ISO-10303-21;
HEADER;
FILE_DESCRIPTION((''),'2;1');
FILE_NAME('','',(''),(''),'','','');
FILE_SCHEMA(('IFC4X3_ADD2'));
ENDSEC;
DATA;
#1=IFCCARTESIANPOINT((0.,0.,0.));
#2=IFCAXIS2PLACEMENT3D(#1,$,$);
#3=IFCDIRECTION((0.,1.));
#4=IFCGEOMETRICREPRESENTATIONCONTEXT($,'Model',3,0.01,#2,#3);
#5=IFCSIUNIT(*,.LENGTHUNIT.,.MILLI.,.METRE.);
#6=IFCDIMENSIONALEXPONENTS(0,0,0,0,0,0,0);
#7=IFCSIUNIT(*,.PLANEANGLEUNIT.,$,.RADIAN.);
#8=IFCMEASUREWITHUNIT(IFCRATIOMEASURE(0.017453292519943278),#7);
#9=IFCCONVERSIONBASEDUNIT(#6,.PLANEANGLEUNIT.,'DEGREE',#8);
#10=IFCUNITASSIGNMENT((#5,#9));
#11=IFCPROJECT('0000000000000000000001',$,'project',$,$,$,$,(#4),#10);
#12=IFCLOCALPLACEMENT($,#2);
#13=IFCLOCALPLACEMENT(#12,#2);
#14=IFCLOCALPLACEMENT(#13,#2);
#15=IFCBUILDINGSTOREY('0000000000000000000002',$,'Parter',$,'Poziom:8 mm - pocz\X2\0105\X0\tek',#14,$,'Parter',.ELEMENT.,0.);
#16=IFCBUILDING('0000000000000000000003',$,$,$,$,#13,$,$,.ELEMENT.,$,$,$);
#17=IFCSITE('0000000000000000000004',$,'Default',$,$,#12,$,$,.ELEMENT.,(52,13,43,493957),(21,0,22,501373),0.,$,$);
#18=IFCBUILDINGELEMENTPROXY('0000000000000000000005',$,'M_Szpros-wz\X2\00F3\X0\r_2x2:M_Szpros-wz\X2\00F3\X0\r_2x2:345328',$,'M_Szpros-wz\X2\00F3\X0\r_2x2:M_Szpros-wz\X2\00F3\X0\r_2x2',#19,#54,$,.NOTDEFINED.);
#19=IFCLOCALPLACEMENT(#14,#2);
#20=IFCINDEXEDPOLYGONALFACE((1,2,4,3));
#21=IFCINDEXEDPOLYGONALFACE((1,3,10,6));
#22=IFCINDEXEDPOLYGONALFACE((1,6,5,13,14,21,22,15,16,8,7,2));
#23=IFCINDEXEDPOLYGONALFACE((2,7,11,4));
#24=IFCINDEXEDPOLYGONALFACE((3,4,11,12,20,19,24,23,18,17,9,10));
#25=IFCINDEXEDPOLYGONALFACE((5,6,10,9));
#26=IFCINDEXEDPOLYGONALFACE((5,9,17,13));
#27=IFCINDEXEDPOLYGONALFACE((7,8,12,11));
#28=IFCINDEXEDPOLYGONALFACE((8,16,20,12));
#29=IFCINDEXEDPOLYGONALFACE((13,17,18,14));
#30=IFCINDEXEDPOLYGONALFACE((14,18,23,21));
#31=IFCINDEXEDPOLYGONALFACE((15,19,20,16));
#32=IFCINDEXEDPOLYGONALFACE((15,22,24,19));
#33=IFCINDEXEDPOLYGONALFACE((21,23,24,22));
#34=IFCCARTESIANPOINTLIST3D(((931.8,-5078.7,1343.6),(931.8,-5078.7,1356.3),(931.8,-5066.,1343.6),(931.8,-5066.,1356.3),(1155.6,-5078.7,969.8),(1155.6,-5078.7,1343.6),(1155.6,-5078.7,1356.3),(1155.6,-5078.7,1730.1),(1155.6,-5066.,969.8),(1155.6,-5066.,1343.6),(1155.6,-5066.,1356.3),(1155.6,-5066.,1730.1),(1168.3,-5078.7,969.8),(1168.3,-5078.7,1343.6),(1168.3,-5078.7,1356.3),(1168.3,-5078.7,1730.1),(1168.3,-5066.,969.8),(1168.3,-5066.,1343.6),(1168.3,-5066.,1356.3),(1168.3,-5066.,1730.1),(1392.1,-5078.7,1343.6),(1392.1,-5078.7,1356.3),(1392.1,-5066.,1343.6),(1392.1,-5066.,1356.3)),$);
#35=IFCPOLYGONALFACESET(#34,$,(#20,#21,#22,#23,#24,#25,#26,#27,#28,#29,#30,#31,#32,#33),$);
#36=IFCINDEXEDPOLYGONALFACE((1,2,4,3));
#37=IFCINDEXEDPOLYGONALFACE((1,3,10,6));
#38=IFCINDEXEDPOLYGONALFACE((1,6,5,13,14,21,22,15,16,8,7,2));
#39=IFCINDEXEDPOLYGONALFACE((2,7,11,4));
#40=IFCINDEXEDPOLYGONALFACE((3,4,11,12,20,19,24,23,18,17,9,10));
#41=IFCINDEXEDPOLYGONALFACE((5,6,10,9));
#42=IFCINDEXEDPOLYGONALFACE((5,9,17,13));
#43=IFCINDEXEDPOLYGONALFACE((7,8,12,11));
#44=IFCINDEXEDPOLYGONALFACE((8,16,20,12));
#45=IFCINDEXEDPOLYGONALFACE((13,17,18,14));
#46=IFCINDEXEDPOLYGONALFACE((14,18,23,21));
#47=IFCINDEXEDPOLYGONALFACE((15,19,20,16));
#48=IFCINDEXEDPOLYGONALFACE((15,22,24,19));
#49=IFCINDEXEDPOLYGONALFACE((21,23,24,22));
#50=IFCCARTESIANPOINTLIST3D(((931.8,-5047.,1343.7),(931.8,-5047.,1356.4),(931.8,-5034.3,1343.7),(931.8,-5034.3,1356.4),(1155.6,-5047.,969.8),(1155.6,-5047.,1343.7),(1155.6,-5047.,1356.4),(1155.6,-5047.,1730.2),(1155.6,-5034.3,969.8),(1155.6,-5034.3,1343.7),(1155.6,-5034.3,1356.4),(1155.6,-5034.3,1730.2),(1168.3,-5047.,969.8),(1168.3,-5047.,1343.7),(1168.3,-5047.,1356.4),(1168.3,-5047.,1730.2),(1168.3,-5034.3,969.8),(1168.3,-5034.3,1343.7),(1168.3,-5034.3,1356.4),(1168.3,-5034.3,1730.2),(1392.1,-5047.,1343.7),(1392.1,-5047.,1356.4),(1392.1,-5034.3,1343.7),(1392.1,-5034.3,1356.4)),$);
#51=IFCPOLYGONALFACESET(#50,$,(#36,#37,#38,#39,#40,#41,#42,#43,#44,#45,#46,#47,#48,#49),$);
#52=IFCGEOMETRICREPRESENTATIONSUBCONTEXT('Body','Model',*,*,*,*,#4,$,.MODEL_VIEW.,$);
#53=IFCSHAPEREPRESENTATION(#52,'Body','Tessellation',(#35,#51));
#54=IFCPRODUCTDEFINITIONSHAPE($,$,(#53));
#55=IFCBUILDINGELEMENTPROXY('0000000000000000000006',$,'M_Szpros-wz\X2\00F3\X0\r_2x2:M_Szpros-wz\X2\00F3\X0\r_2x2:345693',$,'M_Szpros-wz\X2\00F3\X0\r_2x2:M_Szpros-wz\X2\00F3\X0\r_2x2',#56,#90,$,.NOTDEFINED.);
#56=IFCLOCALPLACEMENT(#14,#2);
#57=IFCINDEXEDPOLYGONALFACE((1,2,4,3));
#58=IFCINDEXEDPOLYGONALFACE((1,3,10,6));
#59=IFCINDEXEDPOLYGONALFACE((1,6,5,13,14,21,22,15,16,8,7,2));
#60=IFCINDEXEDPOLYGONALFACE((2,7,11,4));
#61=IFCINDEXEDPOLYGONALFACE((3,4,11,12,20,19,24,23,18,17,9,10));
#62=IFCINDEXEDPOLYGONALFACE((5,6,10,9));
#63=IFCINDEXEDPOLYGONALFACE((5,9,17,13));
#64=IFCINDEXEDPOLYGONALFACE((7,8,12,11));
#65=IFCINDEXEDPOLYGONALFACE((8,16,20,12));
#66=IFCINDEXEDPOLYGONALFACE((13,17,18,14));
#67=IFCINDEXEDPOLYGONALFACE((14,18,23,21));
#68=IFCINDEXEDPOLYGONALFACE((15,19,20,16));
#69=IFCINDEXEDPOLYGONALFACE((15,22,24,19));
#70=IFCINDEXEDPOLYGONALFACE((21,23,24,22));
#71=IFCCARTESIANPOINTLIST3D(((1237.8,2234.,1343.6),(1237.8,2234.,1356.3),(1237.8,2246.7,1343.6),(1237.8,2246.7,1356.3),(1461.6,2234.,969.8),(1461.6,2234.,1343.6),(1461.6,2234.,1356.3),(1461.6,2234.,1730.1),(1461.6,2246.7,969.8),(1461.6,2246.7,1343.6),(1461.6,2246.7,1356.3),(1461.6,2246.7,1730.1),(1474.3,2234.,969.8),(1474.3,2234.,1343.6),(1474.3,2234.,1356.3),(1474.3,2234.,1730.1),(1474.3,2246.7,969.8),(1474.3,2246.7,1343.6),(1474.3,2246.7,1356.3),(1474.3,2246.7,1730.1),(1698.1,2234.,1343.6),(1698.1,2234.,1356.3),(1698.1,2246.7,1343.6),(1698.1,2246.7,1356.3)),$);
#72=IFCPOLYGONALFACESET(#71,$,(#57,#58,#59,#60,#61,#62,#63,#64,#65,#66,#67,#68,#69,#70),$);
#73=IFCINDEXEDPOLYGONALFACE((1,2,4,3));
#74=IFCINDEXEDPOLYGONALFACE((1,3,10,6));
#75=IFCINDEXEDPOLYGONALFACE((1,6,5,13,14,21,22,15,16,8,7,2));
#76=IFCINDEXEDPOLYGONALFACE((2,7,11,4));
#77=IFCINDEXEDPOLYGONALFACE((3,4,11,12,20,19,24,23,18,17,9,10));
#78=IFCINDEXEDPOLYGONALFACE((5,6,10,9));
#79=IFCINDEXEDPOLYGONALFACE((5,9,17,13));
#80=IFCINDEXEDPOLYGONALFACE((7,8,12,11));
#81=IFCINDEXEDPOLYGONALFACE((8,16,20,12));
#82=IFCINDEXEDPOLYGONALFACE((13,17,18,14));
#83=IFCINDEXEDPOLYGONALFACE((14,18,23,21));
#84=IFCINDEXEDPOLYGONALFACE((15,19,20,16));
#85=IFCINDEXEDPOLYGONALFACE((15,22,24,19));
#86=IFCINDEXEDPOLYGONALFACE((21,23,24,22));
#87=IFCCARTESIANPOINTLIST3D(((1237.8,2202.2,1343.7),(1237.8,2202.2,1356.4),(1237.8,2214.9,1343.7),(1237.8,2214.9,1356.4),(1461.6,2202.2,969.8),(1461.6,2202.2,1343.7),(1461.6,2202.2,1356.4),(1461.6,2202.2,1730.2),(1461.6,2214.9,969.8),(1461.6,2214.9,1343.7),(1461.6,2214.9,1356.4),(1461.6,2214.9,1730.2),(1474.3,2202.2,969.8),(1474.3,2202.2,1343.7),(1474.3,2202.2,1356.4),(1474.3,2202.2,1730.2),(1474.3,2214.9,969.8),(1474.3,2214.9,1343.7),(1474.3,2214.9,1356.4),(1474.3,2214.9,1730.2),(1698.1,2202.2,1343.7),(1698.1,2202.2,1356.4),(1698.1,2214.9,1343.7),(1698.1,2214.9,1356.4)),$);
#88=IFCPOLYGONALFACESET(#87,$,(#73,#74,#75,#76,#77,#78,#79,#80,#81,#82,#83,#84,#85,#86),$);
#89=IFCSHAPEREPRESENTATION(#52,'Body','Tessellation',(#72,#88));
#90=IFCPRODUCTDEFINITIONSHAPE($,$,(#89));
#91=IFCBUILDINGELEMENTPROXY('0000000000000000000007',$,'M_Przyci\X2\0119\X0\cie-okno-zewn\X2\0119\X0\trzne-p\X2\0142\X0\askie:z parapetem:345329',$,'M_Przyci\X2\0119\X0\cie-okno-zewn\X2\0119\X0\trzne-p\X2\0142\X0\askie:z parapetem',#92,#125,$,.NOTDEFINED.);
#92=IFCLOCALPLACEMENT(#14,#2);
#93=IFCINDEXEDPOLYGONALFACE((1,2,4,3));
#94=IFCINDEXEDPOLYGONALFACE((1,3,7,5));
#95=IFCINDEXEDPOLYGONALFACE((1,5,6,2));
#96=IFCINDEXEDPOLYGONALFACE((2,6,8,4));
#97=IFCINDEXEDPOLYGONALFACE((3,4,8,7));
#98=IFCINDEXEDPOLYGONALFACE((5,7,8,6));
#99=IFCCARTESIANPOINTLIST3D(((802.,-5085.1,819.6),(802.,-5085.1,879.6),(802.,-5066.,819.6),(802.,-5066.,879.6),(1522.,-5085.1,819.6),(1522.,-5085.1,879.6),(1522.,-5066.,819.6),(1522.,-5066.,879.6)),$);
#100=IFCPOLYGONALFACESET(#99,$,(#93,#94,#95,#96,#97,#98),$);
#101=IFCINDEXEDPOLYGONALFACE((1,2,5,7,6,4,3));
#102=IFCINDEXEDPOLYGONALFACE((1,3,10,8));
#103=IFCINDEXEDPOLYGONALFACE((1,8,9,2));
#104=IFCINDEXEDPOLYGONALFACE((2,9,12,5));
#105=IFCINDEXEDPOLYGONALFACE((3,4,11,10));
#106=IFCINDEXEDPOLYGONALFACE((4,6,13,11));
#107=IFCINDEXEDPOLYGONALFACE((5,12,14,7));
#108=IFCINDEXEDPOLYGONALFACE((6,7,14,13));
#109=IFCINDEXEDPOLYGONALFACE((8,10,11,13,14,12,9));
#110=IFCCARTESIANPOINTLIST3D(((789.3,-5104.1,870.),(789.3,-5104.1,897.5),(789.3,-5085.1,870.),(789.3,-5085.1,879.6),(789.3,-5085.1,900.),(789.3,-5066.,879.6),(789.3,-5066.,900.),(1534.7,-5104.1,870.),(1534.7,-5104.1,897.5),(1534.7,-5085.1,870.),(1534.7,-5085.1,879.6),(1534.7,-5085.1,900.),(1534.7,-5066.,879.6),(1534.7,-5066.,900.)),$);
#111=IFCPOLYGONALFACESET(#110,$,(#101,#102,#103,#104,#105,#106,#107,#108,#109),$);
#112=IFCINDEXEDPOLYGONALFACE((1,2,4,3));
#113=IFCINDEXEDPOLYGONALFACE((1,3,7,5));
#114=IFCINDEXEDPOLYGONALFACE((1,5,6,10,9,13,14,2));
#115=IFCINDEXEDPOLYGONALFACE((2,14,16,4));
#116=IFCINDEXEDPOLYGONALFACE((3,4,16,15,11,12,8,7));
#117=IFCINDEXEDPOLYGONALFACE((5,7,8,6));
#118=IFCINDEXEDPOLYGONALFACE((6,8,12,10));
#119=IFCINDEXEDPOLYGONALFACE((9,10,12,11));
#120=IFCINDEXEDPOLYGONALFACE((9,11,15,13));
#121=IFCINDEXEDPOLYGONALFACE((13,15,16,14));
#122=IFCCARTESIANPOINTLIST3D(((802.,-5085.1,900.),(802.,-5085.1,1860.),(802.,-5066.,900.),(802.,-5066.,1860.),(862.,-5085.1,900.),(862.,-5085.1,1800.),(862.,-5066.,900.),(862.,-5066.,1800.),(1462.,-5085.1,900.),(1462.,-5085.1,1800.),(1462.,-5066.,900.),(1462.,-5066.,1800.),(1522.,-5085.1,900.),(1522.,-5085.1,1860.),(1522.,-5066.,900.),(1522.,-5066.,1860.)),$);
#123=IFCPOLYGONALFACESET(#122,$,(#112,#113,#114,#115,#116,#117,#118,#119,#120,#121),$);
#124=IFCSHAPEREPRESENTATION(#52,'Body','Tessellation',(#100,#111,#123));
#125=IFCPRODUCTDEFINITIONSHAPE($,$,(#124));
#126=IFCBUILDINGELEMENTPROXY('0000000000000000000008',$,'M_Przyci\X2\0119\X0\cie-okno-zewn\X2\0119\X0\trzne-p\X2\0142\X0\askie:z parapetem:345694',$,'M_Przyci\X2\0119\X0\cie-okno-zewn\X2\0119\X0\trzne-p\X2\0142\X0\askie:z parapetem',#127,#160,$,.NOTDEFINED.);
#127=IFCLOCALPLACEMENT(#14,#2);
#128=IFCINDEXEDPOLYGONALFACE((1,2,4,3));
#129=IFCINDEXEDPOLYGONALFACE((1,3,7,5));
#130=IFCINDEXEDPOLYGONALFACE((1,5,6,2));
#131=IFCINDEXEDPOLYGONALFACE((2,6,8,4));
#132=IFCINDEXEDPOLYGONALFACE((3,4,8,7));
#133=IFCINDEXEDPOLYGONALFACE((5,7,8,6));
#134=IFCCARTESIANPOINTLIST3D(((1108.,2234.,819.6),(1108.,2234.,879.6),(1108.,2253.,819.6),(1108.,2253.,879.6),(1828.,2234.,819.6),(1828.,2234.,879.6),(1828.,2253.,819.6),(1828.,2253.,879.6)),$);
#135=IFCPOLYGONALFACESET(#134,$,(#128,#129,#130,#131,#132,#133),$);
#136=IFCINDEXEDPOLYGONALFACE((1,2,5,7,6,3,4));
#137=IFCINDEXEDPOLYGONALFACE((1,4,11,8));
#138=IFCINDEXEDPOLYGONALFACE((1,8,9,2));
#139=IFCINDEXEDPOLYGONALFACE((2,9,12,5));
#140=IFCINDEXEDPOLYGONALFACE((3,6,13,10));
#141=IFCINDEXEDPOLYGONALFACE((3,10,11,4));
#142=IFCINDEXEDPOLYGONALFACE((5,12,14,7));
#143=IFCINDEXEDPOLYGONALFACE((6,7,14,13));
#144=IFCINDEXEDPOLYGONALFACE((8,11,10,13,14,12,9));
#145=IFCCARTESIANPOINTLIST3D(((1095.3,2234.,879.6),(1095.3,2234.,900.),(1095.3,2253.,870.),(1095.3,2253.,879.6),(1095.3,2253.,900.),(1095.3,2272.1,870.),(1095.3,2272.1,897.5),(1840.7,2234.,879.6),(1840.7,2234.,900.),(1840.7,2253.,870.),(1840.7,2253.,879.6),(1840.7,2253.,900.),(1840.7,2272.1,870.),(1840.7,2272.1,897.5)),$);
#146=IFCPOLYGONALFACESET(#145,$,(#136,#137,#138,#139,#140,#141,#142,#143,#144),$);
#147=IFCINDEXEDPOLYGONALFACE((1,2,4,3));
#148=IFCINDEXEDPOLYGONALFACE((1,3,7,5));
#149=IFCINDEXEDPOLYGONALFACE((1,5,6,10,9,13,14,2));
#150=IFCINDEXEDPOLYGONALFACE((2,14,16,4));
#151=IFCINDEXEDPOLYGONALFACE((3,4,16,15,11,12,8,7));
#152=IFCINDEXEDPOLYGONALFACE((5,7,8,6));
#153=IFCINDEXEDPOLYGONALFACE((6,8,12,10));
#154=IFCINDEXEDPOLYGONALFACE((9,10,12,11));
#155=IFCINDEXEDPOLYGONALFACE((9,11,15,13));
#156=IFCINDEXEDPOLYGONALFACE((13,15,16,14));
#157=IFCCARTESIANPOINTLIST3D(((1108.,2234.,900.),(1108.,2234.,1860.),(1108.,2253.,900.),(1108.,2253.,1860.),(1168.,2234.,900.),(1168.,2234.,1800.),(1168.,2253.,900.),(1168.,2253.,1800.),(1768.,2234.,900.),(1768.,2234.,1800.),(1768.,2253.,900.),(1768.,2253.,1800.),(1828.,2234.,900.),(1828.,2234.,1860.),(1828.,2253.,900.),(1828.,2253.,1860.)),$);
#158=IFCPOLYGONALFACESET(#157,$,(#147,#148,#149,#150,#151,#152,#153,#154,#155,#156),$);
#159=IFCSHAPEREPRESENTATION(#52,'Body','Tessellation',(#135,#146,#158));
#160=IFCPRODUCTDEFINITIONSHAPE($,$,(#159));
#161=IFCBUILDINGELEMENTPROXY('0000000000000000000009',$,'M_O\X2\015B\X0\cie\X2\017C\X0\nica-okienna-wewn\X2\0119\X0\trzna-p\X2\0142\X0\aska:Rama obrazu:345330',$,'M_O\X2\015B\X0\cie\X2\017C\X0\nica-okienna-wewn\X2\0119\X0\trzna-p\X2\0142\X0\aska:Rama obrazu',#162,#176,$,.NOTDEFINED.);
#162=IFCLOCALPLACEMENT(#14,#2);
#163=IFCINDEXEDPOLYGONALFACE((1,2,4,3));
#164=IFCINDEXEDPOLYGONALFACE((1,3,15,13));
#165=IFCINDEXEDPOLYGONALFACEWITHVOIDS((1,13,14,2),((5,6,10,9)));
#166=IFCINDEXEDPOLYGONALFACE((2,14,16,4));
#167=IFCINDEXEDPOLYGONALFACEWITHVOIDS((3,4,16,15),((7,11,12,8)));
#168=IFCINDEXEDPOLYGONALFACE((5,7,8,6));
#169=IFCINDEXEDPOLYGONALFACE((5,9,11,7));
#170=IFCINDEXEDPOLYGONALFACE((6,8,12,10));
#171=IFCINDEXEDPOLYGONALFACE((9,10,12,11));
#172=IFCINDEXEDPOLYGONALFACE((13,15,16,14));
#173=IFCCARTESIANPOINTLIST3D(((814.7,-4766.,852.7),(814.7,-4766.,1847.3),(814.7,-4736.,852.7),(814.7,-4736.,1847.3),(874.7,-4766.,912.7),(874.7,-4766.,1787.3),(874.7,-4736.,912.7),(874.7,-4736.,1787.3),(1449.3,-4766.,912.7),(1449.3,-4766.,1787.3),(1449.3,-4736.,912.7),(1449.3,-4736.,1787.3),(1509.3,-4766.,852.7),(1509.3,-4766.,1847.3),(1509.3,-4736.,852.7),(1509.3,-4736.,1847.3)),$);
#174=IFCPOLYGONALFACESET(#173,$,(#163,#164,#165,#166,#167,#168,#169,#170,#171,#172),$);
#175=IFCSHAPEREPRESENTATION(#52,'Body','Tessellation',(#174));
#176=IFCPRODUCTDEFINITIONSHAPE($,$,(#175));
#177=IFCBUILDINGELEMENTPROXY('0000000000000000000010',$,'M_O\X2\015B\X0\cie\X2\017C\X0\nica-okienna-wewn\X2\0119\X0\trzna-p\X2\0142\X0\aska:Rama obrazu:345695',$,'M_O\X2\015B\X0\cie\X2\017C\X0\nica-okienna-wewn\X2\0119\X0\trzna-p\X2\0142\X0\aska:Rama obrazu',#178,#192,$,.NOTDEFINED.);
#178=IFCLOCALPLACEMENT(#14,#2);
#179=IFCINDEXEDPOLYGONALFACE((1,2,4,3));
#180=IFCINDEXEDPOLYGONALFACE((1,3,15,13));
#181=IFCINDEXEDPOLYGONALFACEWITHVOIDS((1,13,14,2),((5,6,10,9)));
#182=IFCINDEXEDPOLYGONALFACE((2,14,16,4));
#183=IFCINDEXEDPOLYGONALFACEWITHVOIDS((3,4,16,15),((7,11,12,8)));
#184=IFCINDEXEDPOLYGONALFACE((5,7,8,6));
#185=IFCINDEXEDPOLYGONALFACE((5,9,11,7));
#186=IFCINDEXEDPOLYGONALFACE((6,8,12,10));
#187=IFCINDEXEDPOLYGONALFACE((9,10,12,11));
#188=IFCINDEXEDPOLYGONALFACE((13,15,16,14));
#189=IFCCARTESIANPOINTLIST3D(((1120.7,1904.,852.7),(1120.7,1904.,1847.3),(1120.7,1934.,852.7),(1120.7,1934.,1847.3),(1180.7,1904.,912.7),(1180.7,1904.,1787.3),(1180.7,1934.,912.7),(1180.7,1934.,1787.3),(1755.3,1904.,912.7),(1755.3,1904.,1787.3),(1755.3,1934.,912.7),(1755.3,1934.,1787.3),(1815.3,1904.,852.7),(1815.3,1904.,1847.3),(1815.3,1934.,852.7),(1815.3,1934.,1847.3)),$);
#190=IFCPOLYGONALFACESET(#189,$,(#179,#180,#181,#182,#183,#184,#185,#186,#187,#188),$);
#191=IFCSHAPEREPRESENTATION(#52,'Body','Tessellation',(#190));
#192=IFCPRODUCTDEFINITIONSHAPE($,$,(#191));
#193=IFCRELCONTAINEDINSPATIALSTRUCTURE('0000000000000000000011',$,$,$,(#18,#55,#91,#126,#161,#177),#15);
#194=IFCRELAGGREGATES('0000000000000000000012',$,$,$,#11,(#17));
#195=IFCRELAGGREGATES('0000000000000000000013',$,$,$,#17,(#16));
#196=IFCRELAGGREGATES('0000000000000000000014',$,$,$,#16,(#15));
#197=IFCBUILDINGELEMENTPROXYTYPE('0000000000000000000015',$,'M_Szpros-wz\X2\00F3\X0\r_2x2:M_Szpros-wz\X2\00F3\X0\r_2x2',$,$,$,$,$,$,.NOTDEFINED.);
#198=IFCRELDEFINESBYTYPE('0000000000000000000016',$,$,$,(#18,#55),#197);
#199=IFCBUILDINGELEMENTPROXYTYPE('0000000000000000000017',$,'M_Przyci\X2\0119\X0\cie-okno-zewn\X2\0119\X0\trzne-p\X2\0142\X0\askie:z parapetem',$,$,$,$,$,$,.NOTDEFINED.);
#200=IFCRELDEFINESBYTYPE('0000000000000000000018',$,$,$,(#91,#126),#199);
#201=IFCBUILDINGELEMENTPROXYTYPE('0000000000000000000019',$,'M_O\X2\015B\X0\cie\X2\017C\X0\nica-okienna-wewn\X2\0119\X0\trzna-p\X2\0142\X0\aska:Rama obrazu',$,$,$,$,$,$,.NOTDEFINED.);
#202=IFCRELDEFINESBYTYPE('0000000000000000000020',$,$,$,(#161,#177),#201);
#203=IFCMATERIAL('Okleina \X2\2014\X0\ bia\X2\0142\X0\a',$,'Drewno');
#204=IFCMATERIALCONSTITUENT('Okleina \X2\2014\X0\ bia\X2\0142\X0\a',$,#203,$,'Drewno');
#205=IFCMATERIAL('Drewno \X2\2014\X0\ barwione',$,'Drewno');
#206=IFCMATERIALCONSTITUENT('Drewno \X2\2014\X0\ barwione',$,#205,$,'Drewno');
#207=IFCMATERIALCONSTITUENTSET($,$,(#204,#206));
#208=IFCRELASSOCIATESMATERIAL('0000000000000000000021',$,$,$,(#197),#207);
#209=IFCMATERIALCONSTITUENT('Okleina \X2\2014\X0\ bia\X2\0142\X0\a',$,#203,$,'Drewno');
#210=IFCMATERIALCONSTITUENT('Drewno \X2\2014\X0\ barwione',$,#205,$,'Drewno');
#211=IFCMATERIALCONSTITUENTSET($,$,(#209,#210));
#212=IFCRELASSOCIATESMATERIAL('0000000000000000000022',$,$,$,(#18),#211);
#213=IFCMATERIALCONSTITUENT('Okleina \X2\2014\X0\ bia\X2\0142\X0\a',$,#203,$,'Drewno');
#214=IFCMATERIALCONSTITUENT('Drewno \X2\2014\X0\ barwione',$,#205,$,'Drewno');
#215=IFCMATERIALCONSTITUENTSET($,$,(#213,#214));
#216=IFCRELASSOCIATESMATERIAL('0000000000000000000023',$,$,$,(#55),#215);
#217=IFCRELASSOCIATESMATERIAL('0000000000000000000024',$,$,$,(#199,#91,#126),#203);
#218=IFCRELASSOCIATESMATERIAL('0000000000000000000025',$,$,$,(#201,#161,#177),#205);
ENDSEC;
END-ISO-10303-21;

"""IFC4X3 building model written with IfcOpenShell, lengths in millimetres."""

from ifc_helpers import new_model, entity, si_unit, converted_unit, direction, frame, frame_2d, origin, place, context, subcontext, project, spatial, polyline, rectangle, outline, extrude, source, transform, mapped, material, constituent, constituent_set, type_object, type_shapes, element, save


model = new_model("IFC4X3")

# Units and contexts
model_context = context("Model", 3, precision=0.01, world=origin(), true_north=direction((0.0, 1.0)))
body_context = subcontext(model_context, "Body", "Model", "MODEL_VIEW")
ifc_project = project(units=[si_unit("LENGTHUNIT", "METRE", prefix="MILLI"), converted_unit("PLANEANGLEUNIT", "DEGREE", entity("IfcRatioMeasure", 0.017453292519943278), si_unit("PLANEANGLEUNIT", "RADIAN"), dimensions=[0, 0, 0, 0, 0, 0, 0])], contexts=[model_context])

# Site, building, storey
site_placement = place(None, origin())
site = spatial("IfcSite", under=ifc_project, at=site_placement, Name="Default", CompositionType="ELEMENT", RefLatitude=(52, 13, 43, 493957), RefLongitude=(21, 0, 22, 501373), RefElevation=0.0)
building_placement = place(site_placement, origin())
building = spatial("IfcBuilding", under=site, at=building_placement, CompositionType="ELEMENT")
storey_placement = place(building_placement, origin())
storey = spatial("IfcBuildingStorey", under=building, at=storey_placement, Name="Parter", ObjectType="Poziom:8 mm - początek", LongName="Parter", CompositionType="ELEMENT", Elevation=0.0)

# Building element proxies
ifc_material_1 = material(Name="Okleina — biała", Category="Drewno")
ifc_constituent_1 = constituent(ifc_material_1, Name="Okleina — biała", Category="Drewno")
ifc_material_2 = material(Name="Drewno — barwione", Category="Drewno")
ifc_constituent_2 = constituent(ifc_material_2, Name="Drewno — barwione", Category="Drewno")
ifc_constituent_set_1 = constituent_set(constituents=[ifc_constituent_1, ifc_constituent_2])
ifc_constituent_3 = constituent(ifc_material_1, Name="Okleina — biała", Category="Drewno")
ifc_constituent_4 = constituent(ifc_material_2, Name="Drewno — barwione", Category="Drewno")
ifc_constituent_set_2 = constituent_set(constituents=[ifc_constituent_3, ifc_constituent_4])
building_element_proxy_type_1 = type_object("IfcBuildingElementProxyType", Name="M_Szpros-wzór_2x2:M_Szpros-wzór_2x2", PredefinedType="NOTDEFINED", material=ifc_constituent_set_2)
shared_shape_1 = source(origin(), body_context, "Body", "SweptSolid", [
    extrude(outline(polyline([(6.4, -6.4), (380.1, -6.4), (380.1, 6.3), (6.4, 6.3), (6.4, 230.2), (-6.3, 230.2), (-6.3, 6.3), (-380.2, 6.3), (-380.2, -6.4), (-6.3, -6.4), (-6.3, -230.1), (6.4, -230.1), (6.4, -6.4)])), frame((0.0, 9.5, 380.1), z_axis=(0.0, 1.0, 0.0), x_axis=(0.0, 0.0, 1.0)), (0.0, 0.0, 1.0), 12.7),
    extrude(outline(polyline([(6.4, -6.4), (380.2, -6.4), (380.2, 6.3), (6.4, 6.3), (6.4, 230.2), (-6.3, 230.2), (-6.3, 6.3), (-380.2, 6.3), (-380.2, -6.4), (-6.3, -6.4), (-6.3, -230.1), (6.4, -230.1), (6.4, -6.4)])), frame((0.0, -22.2, 380.2), z_axis=(0.0, 1.0, 0.0), x_axis=(0.0, 0.0, 1.0)), (0.0, 0.0, 1.0), 12.7),
])
type_shapes(building_element_proxy_type_1, [shared_shape_1])
proxy_1_placement = place(storey_placement, frame((1162.0, -5056.5, 969.8), z_axis=(0.0, 0.0, 1.0), x_axis=(-1.0, 0.0, 0.0)))
element("IfcBuildingElementProxy", 1, at=proxy_1_placement, inside=storey, type_object=building_element_proxy_type_1, material=ifc_constituent_set_1, Name="M_Szpros-wzór_2x2:M_Szpros-wzór_2x2:345328", ObjectType="M_Szpros-wzór_2x2:M_Szpros-wzór_2x2", PredefinedType="NOTDEFINED", context=body_context, shape_type="MappedRepresentation", body=[
    mapped(shared_shape_1, transform((0.0, 0.0, 0.0), scale=1.0)),
])
ifc_constituent_5 = constituent(ifc_material_1, Name="Okleina — biała", Category="Drewno")
ifc_constituent_6 = constituent(ifc_material_2, Name="Drewno — barwione", Category="Drewno")
ifc_constituent_set_3 = constituent_set(constituents=[ifc_constituent_5, ifc_constituent_6])
proxy_2_placement = place(storey_placement, frame((1468.0, 2224.5, 969.8)))
element("IfcBuildingElementProxy", 2, at=proxy_2_placement, inside=storey, type_object=building_element_proxy_type_1, material=ifc_constituent_set_3, Name="M_Szpros-wzór_2x2:M_Szpros-wzór_2x2:345693", ObjectType="M_Szpros-wzór_2x2:M_Szpros-wzór_2x2", PredefinedType="NOTDEFINED", context=body_context, shape_type="MappedRepresentation", body=[
    mapped(shared_shape_1, transform((0.0, 0.0, 0.0), scale=1.0)),
])
building_element_proxy_type_2 = type_object("IfcBuildingElementProxyType", Name="M_Przycięcie-okno-zewnętrzne-płaskie:z parapetem", PredefinedType="NOTDEFINED", material=ifc_material_1)
shared_shape_2 = source(origin(), body_context, "Body", "SweptSolid", [
    extrude(rectangle(XDim=720.0, YDim=60.0, at=frame_2d((0.0, 0.0), x_axis=(1.0, 0.0))), frame((0.0, -950.4, 0.0), z_axis=(0.0, 0.0, 1.0), x_axis=(-1.0, 0.0, 0.0)), (0.0, 0.0, 1.0), 19.0),
    extrude(outline(polyline([(-19.0, -15.2), (0.0, -15.2), (0.0, -5.7), (19.0, -5.7), (19.0, 14.8), (0.0, 14.8), (-19.0, 12.3), (-19.0, -15.2)])), frame((-372.7, -914.8, 19.0), z_axis=(1.0, 0.0, 0.0), x_axis=(0.0, 0.0, -1.0)), (0.0, 0.0, 1.0), 745.4),
    extrude(outline(polyline([(-495.0, -360.0), (465.0, -360.0), (465.0, -300.0), (-435.0, -300.0), (-435.0, 300.0), (465.0, 300.0), (465.0, 360.0), (-495.0, 360.0), (-495.0, -360.0)])), frame((0.0, -435.0, 0.0), z_axis=(0.0, 0.0, 1.0), x_axis=(0.0, -1.0, 0.0)), (0.0, 0.0, 1.0), 19.0),
])
type_shapes(building_element_proxy_type_2, [shared_shape_2])
for number, where, z_axis, x_axis, name in (
    (3, (1162.0, -5066.0, 1800.0), (0.0, -1.0, 0.0), (1.0, 0.0, 0.0), "M_Przycięcie-okno-zewnętrzne-płaskie:z parapetem:345329"),
    (4, (1468.0, 2234.0, 1800.0), (0.0, 1.0, 0.0), (-1.0, 0.0, 0.0), "M_Przycięcie-okno-zewnętrzne-płaskie:z parapetem:345694"),
):
    element("IfcBuildingElementProxy", number, at=place(storey_placement, frame(where, z_axis=z_axis, x_axis=x_axis)), inside=storey, type_object=building_element_proxy_type_2, material=ifc_material_1, Name=name, ObjectType="M_Przycięcie-okno-zewnętrzne-płaskie:z parapetem", PredefinedType="NOTDEFINED", context=body_context, shape_type="MappedRepresentation", body=[
        mapped(shared_shape_2, transform((0.0, 0.0, 0.0), scale=1.0)),
    ])
building_element_proxy_type_3 = type_object("IfcBuildingElementProxyType", Name="M_Ościeżnica-okienna-wewnętrzna-płaska:Rama obrazu", PredefinedType="NOTDEFINED", material=ifc_material_2)
shared_shape_3 = source(origin(), body_context, "Body", "SweptSolid", [
    extrude(outline(polyline([(-347.3, -497.3), (347.3, -497.3), (347.3, 497.3), (-347.3, 497.3), (-347.3, -497.3)]), holes=[polyline([(-287.3, -437.3), (-287.3, 437.3), (287.3, 437.3), (287.3, -437.3), (-287.3, -437.3)])]), frame((0.0, -450.0, 0.0), z_axis=(0.0, 0.0, 1.0), x_axis=(-1.0, 0.0, 0.0)), (0.0, 0.0, 1.0), 30.0),
])
type_shapes(building_element_proxy_type_3, [shared_shape_3])
for number, where, z_axis, x_axis, name in (
    (5, (1162.0, -4766.0, 1800.0), (0.0, 1.0, 0.0), (-1.0, 0.0, 0.0), "M_Ościeżnica-okienna-wewnętrzna-płaska:Rama obrazu:345330"),
    (6, (1468.0, 1934.0, 1800.0), (0.0, -1.0, 0.0), (1.0, 0.0, 0.0), "M_Ościeżnica-okienna-wewnętrzna-płaska:Rama obrazu:345695"),
):
    element("IfcBuildingElementProxy", number, at=place(storey_placement, frame(where, z_axis=z_axis, x_axis=x_axis)), inside=storey, type_object=building_element_proxy_type_3, material=ifc_material_2, Name=name, ObjectType="M_Ościeżnica-okienna-wewnętrzna-płaska:Rama obrazu", PredefinedType="NOTDEFINED", context=body_context, shape_type="MappedRepresentation", body=[
        mapped(shared_shape_3, transform((0.0, 0.0, 0.0), scale=1.0)),
    ])

save(model, "model.ifc")
